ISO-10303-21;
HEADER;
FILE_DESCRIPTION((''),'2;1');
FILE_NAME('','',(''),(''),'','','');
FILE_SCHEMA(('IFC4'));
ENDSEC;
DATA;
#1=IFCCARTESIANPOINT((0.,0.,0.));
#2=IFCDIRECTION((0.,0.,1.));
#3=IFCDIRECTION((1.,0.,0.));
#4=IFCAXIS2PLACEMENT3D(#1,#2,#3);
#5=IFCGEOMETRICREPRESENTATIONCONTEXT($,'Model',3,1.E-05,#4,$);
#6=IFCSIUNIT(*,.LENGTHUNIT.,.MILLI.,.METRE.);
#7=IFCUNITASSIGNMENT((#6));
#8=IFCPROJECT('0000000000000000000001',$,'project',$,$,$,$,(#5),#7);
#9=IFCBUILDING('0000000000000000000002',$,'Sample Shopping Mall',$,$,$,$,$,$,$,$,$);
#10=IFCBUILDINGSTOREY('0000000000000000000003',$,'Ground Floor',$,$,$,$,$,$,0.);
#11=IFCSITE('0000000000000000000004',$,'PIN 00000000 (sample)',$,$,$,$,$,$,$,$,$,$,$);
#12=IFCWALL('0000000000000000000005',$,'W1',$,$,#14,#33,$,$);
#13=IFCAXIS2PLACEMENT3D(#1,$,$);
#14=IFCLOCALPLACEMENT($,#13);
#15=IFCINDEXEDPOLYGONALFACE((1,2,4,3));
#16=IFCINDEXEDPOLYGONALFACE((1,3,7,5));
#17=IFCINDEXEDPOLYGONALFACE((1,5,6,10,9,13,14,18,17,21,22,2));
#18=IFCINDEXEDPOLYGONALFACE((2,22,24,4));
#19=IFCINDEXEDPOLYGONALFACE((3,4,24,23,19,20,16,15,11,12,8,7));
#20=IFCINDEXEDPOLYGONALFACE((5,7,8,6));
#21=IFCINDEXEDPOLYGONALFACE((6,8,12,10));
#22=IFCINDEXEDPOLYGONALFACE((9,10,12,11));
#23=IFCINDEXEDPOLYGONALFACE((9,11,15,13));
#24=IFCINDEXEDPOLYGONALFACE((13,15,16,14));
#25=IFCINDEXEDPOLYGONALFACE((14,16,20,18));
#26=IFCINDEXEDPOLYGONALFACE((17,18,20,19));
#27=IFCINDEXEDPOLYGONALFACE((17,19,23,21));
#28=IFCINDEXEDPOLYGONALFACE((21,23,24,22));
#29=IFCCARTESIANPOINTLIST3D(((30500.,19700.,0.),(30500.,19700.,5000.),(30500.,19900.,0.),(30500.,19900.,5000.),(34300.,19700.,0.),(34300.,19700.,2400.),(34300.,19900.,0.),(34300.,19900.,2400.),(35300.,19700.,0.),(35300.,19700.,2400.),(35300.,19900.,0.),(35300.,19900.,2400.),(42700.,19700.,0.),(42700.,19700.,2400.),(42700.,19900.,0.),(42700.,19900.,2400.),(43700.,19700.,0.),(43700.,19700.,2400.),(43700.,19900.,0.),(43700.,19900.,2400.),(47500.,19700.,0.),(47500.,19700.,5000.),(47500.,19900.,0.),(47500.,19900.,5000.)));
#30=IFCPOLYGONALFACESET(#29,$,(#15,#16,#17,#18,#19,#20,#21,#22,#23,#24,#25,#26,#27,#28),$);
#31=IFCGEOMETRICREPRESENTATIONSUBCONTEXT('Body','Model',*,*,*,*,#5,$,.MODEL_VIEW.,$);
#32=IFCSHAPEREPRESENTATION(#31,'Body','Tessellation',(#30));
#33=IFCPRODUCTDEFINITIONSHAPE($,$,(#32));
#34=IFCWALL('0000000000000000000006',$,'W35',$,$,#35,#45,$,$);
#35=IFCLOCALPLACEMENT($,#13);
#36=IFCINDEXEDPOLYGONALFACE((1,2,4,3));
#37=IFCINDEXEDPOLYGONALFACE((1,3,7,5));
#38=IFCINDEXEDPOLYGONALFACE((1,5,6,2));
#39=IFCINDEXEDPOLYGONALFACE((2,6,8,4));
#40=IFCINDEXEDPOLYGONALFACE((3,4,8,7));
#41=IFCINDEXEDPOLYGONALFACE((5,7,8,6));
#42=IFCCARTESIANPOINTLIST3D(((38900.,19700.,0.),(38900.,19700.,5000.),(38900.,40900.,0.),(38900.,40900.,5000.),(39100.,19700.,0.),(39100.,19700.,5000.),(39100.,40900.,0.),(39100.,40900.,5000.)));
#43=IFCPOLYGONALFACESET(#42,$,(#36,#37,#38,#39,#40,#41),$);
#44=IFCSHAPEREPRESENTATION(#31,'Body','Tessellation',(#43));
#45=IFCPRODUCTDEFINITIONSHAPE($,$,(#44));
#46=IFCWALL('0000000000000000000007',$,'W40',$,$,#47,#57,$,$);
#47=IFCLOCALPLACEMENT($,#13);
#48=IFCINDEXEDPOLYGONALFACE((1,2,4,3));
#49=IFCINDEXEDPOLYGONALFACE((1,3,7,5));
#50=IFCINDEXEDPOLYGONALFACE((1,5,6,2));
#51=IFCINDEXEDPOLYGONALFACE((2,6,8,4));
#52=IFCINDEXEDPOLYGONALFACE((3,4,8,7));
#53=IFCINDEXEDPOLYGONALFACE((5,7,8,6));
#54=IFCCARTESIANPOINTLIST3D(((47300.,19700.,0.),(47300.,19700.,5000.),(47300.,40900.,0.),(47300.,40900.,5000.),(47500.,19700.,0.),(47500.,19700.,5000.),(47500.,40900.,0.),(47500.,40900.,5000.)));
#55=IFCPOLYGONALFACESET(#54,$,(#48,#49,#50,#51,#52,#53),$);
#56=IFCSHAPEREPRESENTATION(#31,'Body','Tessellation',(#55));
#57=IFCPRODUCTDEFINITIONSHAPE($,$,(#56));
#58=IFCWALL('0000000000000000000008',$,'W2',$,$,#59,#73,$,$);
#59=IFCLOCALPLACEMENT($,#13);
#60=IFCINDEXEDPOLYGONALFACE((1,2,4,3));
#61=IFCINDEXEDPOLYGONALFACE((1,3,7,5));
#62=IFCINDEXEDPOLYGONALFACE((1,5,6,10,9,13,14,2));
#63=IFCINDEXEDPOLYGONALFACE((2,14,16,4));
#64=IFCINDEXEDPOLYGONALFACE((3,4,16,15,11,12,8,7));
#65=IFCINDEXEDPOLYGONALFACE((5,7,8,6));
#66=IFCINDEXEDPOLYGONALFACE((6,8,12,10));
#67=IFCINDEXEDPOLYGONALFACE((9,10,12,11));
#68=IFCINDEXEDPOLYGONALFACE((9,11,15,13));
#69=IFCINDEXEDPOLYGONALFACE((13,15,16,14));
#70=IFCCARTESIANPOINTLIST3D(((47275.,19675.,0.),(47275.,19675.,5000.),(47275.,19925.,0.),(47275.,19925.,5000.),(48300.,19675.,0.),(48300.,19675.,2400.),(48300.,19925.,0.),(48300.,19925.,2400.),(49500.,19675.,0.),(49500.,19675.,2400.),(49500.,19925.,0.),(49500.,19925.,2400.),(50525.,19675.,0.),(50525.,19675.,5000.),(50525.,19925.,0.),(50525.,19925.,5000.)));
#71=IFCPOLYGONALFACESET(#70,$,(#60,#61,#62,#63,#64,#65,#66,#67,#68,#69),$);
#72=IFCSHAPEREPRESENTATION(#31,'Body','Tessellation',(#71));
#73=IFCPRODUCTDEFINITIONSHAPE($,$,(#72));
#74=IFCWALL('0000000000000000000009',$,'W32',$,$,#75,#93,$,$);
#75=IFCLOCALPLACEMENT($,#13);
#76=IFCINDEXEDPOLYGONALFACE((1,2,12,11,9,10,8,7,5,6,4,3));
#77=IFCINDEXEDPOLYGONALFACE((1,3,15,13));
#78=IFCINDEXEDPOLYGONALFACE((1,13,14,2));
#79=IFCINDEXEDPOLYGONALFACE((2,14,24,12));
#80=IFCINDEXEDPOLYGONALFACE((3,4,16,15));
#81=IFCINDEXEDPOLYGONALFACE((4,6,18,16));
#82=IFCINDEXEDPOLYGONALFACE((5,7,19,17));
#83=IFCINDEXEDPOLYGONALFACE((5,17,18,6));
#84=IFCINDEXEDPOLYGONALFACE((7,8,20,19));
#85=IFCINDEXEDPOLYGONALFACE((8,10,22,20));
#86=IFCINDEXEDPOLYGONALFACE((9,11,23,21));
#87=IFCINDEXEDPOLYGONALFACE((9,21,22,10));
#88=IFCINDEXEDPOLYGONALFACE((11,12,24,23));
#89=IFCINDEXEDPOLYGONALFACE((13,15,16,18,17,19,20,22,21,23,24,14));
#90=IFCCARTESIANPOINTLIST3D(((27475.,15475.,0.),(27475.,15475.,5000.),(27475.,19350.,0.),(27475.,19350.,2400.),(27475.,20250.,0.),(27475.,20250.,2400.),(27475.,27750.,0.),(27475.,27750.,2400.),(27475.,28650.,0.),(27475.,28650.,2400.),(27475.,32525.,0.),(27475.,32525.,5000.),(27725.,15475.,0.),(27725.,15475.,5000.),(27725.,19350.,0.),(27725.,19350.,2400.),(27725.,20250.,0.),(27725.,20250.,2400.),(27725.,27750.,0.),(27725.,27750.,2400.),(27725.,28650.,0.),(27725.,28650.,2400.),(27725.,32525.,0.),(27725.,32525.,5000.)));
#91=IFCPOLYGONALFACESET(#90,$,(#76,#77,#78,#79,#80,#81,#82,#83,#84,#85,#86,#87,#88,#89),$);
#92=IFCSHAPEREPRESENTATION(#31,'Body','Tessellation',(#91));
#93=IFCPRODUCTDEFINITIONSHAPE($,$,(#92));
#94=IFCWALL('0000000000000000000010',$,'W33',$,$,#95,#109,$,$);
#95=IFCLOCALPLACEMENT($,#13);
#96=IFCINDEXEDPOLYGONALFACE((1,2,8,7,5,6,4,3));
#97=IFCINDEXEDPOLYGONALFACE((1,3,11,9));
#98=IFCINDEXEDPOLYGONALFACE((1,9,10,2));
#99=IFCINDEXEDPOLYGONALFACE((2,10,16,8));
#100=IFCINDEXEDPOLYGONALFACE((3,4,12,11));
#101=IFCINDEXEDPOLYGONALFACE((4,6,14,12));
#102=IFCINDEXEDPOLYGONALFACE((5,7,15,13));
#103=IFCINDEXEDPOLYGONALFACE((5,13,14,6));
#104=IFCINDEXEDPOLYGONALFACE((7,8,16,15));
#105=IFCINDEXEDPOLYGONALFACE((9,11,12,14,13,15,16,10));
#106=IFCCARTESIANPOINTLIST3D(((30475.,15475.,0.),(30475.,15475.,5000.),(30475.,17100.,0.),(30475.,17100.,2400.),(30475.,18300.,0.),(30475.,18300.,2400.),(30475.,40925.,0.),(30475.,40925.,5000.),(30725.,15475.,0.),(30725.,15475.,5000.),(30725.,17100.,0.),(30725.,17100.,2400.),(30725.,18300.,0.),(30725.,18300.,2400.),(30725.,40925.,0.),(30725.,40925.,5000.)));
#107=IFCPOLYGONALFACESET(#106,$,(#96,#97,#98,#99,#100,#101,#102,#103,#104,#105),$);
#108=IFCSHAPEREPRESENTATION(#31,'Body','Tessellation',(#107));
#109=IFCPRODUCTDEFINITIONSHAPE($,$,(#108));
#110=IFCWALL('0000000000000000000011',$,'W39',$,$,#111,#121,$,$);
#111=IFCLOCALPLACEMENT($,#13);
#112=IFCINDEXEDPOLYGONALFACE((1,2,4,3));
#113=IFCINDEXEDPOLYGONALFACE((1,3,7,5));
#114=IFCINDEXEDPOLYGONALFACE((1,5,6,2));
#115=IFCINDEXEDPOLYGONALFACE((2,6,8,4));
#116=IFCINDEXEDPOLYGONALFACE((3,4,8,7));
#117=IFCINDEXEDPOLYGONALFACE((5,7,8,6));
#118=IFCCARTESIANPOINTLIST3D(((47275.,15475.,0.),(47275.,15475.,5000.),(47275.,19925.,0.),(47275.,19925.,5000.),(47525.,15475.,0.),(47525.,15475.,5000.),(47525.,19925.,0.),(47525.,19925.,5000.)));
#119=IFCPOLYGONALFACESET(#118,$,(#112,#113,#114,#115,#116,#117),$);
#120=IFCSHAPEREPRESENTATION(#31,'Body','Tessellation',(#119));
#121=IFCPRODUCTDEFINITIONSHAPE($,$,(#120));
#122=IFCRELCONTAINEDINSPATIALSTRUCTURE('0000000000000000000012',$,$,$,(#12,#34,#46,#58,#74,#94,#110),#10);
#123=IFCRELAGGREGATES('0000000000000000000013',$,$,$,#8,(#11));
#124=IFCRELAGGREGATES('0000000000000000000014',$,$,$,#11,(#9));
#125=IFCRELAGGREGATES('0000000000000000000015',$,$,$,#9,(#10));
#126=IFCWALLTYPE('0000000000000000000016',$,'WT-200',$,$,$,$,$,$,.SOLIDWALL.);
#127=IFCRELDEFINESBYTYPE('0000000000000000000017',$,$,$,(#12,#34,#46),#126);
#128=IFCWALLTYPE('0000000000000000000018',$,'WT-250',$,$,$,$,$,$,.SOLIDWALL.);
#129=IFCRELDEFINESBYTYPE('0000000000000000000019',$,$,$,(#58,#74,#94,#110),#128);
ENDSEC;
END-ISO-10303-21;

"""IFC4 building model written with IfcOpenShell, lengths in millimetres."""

from ifc_helpers import new_model, si_unit, frame, origin_with_axes, place, context, subcontext, project, spatial, indexed_curve, outline, extrude, type_object, element, save


model = new_model("IFC4")

# Units and contexts
model_context = context("Model", 3, precision=1e-05, world=origin_with_axes())
body_context = subcontext(model_context, "Body", "Model", "MODEL_VIEW")
ifc_project = project(units=[si_unit("LENGTHUNIT", "METRE", prefix="MILLI")], contexts=[model_context])

# Site, building, storey
site = spatial("IfcSite", under=ifc_project, Name="PIN 00000000 (sample)")
building = spatial("IfcBuilding", under=site, Name="Sample Shopping Mall")
storey = spatial("IfcBuildingStorey", under=building, Name="Ground Floor", Elevation=0.0)

# Wall, openings
wall_type_1 = type_object("IfcWallType", Name="WT-200", PredefinedType="SOLIDWALL")
wall_1_placement = place(None, frame((30500.0, 19700.0, 0.0), z_axis=(0.0, 0.0, 1.0), x_axis=(1.0, 0.0, 0.0)))
wall_1 = element("IfcWall", 1, at=wall_1_placement, inside=storey, type_object=wall_type_1, Name="W1", context=body_context, shape_type="SweptSolid", body=[
    extrude(outline(indexed_curve([(0.0, 0.0), (0.0, 200.0), (17000.0, 200.0), (17000.0, 0.0), (0.0, 0.0)], self_intersect=False)), origin_with_axes(), (0.0, 0.0, 1.0), 5000.0),
])
opening_1_placement = place(wall_1_placement, frame((3800.0, -100.0, 0.0), z_axis=(0.0, 0.0, 1.0), x_axis=(1.0, 0.0, 0.0)))
element("IfcOpeningElement", 2, at=opening_1_placement, cuts=wall_1, context=body_context, shape_type="SweptSolid", body=[
    extrude(outline(indexed_curve([(0.0, 0.0), (0.0, 400.0), (1000.0, 400.0), (1000.0, 0.0), (0.0, 0.0)], self_intersect=False)), origin_with_axes(), (0.0, 0.0, 1.0), 2400.0),
])
opening_2_placement = place(wall_1_placement, frame((12200.0, -100.0, 0.0), z_axis=(0.0, 0.0, 1.0), x_axis=(1.0, 0.0, 0.0)))
element("IfcOpeningElement", 3, at=opening_2_placement, cuts=wall_1, context=body_context, shape_type="SweptSolid", body=[
    extrude(outline(indexed_curve([(0.0, 0.0), (0.0, 400.0), (1000.0, 400.0), (1000.0, 0.0), (0.0, 0.0)], self_intersect=False)), origin_with_axes(), (0.0, 0.0, 1.0), 2400.0),
])

# Walls
for number, where, z_axis, x_axis, name in (
    (4, (39100.0, 19700.0, 0.0), (0.0, 0.0, 1.0), (0.0, 1.0, 0.0), "W35"),
    (5, (47500.0, 19700.0, 0.0), (0.0, 0.0, 1.0), (0.0, 1.0, 0.0), "W40"),
):
    element("IfcWall", number, at=place(None, frame(where, z_axis=z_axis, x_axis=x_axis)), inside=storey, type_object=wall_type_1, Name=name, context=body_context, shape_type="SweptSolid", body=[
        extrude(outline(indexed_curve([(0.0, 0.0), (0.0, 200.0), (21200.0, 200.0), (21200.0, 0.0), (0.0, 0.0)], self_intersect=False)), origin_with_axes(), (0.0, 0.0, 1.0), 5000.0),
    ])

# Wall, opening
wall_type_2 = type_object("IfcWallType", Name="WT-250", PredefinedType="SOLIDWALL")
wall_2_placement = place(None, frame((47275.0, 19675.0, 0.0), z_axis=(0.0, 0.0, 1.0), x_axis=(1.0, 0.0, 0.0)))
wall_2 = element("IfcWall", 6, at=wall_2_placement, inside=storey, type_object=wall_type_2, Name="W2", context=body_context, shape_type="SweptSolid", body=[
    extrude(outline(indexed_curve([(0.0, 0.0), (0.0, 250.0), (3250.0, 250.0), (3250.0, 0.0), (0.0, 0.0)], self_intersect=False)), origin_with_axes(), (0.0, 0.0, 1.0), 5000.0),
])
opening_3_placement = place(wall_2_placement, frame((1025.0, -100.0, 0.0), z_axis=(0.0, 0.0, 1.0), x_axis=(1.0, 0.0, 0.0)))
element("IfcOpeningElement", 7, at=opening_3_placement, cuts=wall_2, context=body_context, shape_type="SweptSolid", body=[
    extrude(outline(indexed_curve([(0.0, 0.0), (0.0, 450.0), (1200.0, 450.0), (1200.0, 0.0), (0.0, 0.0)], self_intersect=False)), origin_with_axes(), (0.0, 0.0, 1.0), 2400.0),
])

# Wall, openings
wall_3_placement = place(None, frame((27725.0, 15475.0, 0.0), z_axis=(0.0, 0.0, 1.0), x_axis=(0.0, 1.0, 0.0)))
wall_3 = element("IfcWall", 8, at=wall_3_placement, inside=storey, type_object=wall_type_2, Name="W32", context=body_context, shape_type="SweptSolid", body=[
    extrude(outline(indexed_curve([(0.0, 0.0), (0.0, 250.0), (17050.0, 250.0), (17050.0, 0.0), (0.0, 0.0)], self_intersect=False)), origin_with_axes(), (0.0, 0.0, 1.0), 5000.0),
])
opening_4_placement = place(wall_3_placement, frame((12275.0, -100.0, 0.0), z_axis=(0.0, 0.0, 1.0), x_axis=(1.0, 0.0, 0.0)))
element("IfcOpeningElement", 9, at=opening_4_placement, cuts=wall_3, context=body_context, shape_type="SweptSolid", body=[
    extrude(outline(indexed_curve([(0.0, 0.0), (0.0, 450.0), (900.0, 450.0), (900.0, 0.0), (0.0, 0.0)], self_intersect=False)), origin_with_axes(), (0.0, 0.0, 1.0), 2400.0),
])
opening_5_placement = place(wall_3_placement, frame((3875.0, -100.0, 0.0), z_axis=(0.0, 0.0, 1.0), x_axis=(1.0, 0.0, 0.0)))
element("IfcOpeningElement", 10, at=opening_5_placement, cuts=wall_3, context=body_context, shape_type="SweptSolid", body=[
    extrude(outline(indexed_curve([(0.0, 0.0), (0.0, 450.0), (900.0, 450.0), (900.0, 0.0), (0.0, 0.0)], self_intersect=False)), origin_with_axes(), (0.0, 0.0, 1.0), 2400.0),
])

# Wall, opening
wall_4_placement = place(None, frame((30725.0, 15475.0, 0.0), z_axis=(0.0, 0.0, 1.0), x_axis=(0.0, 1.0, 0.0)))
wall_4 = element("IfcWall", 11, at=wall_4_placement, inside=storey, type_object=wall_type_2, Name="W33", context=body_context, shape_type="SweptSolid", body=[
    extrude(outline(indexed_curve([(0.0, 0.0), (0.0, 250.0), (25450.0, 250.0), (25450.0, 0.0), (0.0, 0.0)], self_intersect=False)), origin_with_axes(), (0.0, 0.0, 1.0), 5000.0),
])
opening_6_placement = place(wall_4_placement, frame((1625.0, -100.0, 0.0), z_axis=(0.0, 0.0, 1.0), x_axis=(1.0, 0.0, 0.0)))
element("IfcOpeningElement", 12, at=opening_6_placement, cuts=wall_4, context=body_context, shape_type="SweptSolid", body=[
    extrude(outline(indexed_curve([(0.0, 0.0), (0.0, 450.0), (1200.0, 450.0), (1200.0, 0.0), (0.0, 0.0)], self_intersect=False)), origin_with_axes(), (0.0, 0.0, 1.0), 2400.0),
])

# Wall
wall_5_placement = place(None, frame((47525.0, 15475.0, 0.0), z_axis=(0.0, 0.0, 1.0), x_axis=(0.0, 1.0, 0.0)))
element("IfcWall", 13, at=wall_5_placement, inside=storey, type_object=wall_type_2, Name="W39", context=body_context, shape_type="SweptSolid", body=[
    extrude(outline(indexed_curve([(0.0, 0.0), (0.0, 250.0), (4450.0, 250.0), (4450.0, 0.0), (0.0, 0.0)], self_intersect=False)), origin_with_axes(), (0.0, 0.0, 1.0), 5000.0),
])

save(model, "model.ifc")
